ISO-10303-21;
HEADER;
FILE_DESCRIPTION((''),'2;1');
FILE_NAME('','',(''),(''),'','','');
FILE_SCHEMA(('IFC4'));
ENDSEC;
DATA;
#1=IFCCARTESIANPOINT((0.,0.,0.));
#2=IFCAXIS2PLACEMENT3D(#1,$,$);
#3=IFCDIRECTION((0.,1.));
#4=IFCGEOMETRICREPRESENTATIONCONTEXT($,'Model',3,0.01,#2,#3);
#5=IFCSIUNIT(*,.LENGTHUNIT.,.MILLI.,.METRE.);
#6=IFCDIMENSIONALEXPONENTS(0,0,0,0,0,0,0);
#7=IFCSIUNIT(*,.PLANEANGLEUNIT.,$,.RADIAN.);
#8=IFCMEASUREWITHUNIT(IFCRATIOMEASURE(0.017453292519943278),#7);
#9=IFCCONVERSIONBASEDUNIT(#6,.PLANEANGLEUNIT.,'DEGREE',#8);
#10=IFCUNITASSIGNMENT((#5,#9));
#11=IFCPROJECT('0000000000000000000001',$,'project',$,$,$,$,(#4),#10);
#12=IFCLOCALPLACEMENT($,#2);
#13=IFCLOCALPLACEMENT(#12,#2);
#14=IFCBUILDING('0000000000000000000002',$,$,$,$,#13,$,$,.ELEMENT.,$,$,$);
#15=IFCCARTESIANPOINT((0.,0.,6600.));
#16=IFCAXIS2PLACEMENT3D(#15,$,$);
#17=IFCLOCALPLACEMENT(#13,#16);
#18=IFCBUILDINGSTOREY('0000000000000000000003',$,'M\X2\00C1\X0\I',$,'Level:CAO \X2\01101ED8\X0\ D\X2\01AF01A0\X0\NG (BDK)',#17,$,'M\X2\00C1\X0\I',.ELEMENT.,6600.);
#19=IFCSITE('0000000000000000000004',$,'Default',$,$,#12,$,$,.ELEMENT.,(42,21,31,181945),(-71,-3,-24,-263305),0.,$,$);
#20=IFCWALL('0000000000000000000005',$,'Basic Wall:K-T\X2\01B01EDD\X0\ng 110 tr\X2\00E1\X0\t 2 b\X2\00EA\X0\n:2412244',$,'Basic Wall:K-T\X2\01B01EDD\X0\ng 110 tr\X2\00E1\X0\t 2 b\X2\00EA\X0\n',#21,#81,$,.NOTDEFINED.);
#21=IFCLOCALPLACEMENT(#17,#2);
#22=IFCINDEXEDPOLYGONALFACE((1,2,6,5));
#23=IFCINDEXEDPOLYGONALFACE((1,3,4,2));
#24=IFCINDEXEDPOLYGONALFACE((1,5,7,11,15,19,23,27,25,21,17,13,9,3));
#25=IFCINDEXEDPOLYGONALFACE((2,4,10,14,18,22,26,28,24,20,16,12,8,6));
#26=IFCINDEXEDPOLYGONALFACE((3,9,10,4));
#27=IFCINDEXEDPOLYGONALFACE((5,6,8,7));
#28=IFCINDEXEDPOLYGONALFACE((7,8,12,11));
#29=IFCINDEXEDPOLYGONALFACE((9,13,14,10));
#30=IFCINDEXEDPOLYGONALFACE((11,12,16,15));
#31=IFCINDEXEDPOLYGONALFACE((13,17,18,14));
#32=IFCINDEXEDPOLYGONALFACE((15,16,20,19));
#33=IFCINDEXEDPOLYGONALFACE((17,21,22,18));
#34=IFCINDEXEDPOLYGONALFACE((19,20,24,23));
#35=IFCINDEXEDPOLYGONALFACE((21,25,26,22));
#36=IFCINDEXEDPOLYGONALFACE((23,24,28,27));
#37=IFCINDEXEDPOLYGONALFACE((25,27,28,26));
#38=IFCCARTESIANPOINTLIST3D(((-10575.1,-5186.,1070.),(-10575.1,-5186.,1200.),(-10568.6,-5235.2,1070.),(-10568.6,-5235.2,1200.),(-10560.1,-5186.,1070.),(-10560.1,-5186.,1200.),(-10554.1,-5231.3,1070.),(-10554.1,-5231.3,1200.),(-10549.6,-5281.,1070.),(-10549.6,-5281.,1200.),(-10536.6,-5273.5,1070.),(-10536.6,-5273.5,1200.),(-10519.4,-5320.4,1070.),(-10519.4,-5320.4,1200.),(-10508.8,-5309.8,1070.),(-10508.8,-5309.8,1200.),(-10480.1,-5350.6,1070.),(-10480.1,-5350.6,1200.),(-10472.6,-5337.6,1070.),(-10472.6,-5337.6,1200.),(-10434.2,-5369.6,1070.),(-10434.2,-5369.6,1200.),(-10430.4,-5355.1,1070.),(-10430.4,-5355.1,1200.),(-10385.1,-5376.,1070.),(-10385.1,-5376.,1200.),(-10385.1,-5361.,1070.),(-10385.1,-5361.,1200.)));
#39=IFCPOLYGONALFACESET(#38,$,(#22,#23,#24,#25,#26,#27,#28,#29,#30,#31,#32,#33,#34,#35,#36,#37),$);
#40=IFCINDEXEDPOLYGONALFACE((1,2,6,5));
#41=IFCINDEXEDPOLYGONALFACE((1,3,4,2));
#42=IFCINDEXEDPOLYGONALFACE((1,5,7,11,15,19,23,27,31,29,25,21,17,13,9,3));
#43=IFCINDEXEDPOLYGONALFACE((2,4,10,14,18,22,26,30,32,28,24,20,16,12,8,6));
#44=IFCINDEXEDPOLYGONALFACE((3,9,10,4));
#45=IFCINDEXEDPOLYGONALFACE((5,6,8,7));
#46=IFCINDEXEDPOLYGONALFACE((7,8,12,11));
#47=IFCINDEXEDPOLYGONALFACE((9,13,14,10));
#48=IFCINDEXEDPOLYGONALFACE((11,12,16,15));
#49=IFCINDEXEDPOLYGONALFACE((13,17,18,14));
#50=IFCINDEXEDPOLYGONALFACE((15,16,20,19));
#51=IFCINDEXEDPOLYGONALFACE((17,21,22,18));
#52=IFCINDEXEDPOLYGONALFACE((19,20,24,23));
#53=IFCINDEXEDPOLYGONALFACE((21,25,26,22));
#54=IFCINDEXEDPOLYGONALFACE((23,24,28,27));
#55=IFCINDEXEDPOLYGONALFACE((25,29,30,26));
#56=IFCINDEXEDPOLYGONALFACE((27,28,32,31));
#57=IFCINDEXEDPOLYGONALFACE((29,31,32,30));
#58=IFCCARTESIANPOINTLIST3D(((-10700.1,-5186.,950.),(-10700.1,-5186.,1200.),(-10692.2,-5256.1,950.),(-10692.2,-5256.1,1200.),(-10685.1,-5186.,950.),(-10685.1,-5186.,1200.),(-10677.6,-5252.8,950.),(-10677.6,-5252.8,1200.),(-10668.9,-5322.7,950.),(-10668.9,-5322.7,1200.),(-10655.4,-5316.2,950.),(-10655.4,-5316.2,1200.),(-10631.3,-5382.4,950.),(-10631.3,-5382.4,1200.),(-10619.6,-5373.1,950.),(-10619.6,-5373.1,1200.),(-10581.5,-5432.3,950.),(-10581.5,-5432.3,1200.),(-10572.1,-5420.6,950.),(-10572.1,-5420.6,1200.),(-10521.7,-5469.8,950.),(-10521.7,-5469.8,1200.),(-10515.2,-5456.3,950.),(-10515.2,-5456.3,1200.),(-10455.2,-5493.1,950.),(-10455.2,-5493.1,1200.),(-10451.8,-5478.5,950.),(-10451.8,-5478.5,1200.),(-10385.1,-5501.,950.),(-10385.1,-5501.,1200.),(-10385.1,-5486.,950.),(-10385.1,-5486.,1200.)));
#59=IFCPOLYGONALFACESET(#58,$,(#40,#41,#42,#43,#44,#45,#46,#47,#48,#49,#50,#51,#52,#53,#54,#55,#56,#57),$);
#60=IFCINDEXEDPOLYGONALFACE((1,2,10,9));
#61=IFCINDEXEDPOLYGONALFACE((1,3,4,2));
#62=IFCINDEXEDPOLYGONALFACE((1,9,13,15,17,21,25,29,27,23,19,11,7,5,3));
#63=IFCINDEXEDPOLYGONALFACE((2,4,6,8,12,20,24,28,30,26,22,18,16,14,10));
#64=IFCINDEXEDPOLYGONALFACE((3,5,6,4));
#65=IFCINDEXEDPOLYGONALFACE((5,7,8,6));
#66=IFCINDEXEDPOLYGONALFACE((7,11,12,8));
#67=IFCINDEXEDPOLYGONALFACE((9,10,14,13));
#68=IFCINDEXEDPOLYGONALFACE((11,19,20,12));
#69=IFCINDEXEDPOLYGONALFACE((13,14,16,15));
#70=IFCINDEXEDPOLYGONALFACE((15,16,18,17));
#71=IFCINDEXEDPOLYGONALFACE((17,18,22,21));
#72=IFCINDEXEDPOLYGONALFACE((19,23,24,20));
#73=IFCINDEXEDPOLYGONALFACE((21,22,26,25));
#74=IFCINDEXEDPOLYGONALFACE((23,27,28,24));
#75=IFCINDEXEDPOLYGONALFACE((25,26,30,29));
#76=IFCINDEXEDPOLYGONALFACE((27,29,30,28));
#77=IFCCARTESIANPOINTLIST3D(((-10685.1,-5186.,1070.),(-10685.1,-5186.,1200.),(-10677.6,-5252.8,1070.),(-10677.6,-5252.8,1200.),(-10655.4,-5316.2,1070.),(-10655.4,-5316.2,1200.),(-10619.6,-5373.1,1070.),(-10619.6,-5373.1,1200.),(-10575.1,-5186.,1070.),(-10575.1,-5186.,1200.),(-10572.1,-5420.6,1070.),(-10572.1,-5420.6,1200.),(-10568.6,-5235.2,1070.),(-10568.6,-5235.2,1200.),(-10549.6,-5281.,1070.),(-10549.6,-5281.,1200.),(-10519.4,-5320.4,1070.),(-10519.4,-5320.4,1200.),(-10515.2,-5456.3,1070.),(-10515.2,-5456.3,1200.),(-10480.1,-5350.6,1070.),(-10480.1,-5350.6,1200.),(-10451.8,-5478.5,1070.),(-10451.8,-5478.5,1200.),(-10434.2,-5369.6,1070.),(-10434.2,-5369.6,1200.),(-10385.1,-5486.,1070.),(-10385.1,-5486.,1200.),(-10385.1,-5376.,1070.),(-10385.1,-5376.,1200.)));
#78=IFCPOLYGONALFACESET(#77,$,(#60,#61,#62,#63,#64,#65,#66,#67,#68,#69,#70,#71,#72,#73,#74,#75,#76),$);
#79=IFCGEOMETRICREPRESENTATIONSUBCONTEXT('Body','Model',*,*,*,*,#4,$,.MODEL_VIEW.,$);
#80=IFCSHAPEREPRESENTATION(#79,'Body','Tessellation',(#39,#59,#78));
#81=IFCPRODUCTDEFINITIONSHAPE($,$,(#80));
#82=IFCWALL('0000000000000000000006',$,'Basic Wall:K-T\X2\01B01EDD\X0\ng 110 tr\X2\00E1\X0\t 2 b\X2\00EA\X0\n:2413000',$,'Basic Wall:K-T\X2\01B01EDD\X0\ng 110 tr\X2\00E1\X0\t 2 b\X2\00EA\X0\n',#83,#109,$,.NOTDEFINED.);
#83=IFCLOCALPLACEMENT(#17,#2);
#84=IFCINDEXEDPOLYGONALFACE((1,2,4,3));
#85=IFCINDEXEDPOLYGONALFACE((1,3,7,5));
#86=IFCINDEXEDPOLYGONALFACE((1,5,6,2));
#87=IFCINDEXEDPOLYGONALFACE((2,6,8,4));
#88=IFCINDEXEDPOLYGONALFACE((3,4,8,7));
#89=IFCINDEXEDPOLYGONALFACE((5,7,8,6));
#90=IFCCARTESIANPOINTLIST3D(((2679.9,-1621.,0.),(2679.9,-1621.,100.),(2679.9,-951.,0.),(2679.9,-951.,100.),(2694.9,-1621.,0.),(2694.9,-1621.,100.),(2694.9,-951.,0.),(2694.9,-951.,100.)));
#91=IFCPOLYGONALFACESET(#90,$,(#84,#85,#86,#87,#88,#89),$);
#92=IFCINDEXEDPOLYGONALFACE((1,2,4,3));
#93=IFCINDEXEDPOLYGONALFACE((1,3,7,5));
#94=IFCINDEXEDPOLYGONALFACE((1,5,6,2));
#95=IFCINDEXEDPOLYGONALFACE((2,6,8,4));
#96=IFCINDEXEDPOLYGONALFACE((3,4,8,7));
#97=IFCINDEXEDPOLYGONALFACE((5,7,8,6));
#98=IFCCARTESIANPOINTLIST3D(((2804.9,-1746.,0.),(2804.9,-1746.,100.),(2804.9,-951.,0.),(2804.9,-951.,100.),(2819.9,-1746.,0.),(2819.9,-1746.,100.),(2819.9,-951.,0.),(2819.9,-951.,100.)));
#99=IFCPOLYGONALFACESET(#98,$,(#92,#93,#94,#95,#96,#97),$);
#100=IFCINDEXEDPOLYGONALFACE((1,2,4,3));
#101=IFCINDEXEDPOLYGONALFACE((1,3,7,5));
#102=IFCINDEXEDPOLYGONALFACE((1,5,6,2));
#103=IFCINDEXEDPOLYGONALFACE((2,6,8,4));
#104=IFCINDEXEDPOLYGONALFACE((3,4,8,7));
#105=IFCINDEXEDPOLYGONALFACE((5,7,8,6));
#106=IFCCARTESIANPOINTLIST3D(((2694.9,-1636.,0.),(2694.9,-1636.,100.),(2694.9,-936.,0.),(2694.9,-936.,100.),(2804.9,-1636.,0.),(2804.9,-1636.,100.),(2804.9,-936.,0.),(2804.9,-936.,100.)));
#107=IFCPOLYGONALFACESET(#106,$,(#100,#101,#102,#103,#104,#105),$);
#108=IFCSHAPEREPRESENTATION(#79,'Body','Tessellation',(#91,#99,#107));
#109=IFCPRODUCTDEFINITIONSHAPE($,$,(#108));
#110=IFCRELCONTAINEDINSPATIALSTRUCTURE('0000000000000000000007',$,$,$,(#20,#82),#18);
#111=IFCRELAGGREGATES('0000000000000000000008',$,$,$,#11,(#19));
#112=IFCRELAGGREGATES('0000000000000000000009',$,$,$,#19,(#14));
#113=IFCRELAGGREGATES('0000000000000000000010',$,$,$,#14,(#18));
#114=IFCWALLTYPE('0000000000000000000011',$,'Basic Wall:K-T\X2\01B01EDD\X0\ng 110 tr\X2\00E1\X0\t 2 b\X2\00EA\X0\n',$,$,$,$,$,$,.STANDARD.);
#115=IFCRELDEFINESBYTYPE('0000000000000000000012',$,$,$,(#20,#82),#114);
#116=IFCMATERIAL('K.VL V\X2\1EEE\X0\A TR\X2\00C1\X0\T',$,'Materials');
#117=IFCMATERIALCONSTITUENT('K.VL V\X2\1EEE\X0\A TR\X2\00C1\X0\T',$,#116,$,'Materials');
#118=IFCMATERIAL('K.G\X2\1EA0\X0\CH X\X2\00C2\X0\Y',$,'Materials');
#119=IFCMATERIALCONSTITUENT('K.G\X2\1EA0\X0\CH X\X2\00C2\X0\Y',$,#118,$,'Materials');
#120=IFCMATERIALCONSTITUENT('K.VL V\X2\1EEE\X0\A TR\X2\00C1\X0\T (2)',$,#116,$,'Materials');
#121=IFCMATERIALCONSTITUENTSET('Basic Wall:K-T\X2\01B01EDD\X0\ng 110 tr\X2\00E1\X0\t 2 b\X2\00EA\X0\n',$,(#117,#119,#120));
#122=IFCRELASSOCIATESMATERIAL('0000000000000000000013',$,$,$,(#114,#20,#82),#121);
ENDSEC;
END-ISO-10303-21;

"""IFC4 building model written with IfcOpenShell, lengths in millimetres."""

from ifc_helpers import new_model, entity, si_unit, converted_unit, direction, frame, origin, place, context, subcontext, project, spatial, line, arc, indexed_curve, outline, extrude, material, constituent, constituent_set, type_object, element, save


model = new_model("IFC4")

# Units and contexts
model_context = context("Model", 3, precision=0.01, world=origin(), true_north=direction((0.0, 1.0)))
body_context = subcontext(model_context, "Body", "Model", "MODEL_VIEW")
ifc_project = project(units=[si_unit("LENGTHUNIT", "METRE", prefix="MILLI"), converted_unit("PLANEANGLEUNIT", "DEGREE", entity("IfcRatioMeasure", 0.017453292519943278), si_unit("PLANEANGLEUNIT", "RADIAN"), dimensions=[0, 0, 0, 0, 0, 0, 0])], contexts=[model_context])

# Site, building, storey
site_placement = place(None, origin())
site = spatial("IfcSite", under=ifc_project, at=site_placement, Name="Default", CompositionType="ELEMENT", RefLatitude=(42, 21, 31, 181945), RefLongitude=(-71, -3, -24, -263305), RefElevation=0.0)
building_placement = place(site_placement, origin())
building = spatial("IfcBuilding", under=site, at=building_placement, CompositionType="ELEMENT")
storey_placement = place(building_placement, frame((0.0, 0.0, 6600.0)))
storey = spatial("IfcBuildingStorey", under=building, at=storey_placement, Name="MÁI", ObjectType="Level:CAO ĐỘ DƯƠNG (BDK)", LongName="MÁI", CompositionType="ELEMENT", Elevation=6600.0)

# Walls
ifc_material_1 = material(Name="K.VL VỮA TRÁT", Category="Materials")
ifc_material_2 = material(Name="K.GẠCH XÂY", Category="Materials")
ifc_constituent_1 = constituent(ifc_material_1, Name="K.VL VỮA TRÁT", Category="Materials")
ifc_constituent_2 = constituent(ifc_material_2, Name="K.GẠCH XÂY", Category="Materials")
ifc_constituent_3 = constituent(ifc_material_1, Name="K.VL VỮA TRÁT (2)", Category="Materials")
ifc_constituent_set_1 = constituent_set(constituents=[ifc_constituent_1, ifc_constituent_2, ifc_constituent_3], Name="Basic Wall:K-Tường 110 trát 2 bên")
wall_type_1 = type_object("IfcWallType", Name="Basic Wall:K-Tường 110 trát 2 bên", PredefinedType="STANDARD", material=ifc_constituent_set_1)
wall_1_placement = place(storey_placement, frame((-10385.1, -5431.0, 950.0)))
element("IfcWall", 1, at=wall_1_placement, inside=storey, type_object=wall_type_1, material=ifc_constituent_set_1, Name="Basic Wall:K-Tường 110 trát 2 bên:2412244", ObjectType="Basic Wall:K-Tường 110 trát 2 bên", PredefinedType="NOTDEFINED", context=body_context, shape_type="SweptSolid", body=[
    extrude(outline(indexed_curve([(83.7, -91.2), (98.7, -91.2), (43.1, 43.1), (-91.3, 98.8), (-91.3, 83.8), (32.5, 32.5)], segments=[line(1, 2), arc(2, 3, 4), line(4, 5), arc(5, 6, 1)], self_intersect=False)), frame((-91.3, 153.7, 120.0), z_axis=(0.0, 0.0, 1.0), x_axis=(-1.0, 0.0, 0.0)), (0.0, 0.0, 1.0), 130.0),
    extrude(outline(indexed_curve([(-161.3, 153.7), (-69.0, -69.0), (153.7, -161.2), (153.8, -146.2), (-58.4, -58.4), (-146.3, 153.7)], segments=[arc(1, 2, 3), line(3, 4), arc(4, 5, 6), line(6, 1)], self_intersect=False)), frame((-153.8, 91.2, 0.0), z_axis=(0.0, 0.0, -1.0), x_axis=(0.0, 1.0, 0.0)), (0.0, 0.0, -1.0), 250.0),
    extrude(outline(indexed_curve([(68.8, -121.8), (178.8, -120.6), (88.7, 90.6), (-124.3, 176.2), (-123.2, 66.2), (11.7, 12.0)], segments=[line(1, 2), arc(2, 3, 4), line(4, 5), arc(5, 6, 1)], self_intersect=False)), frame((-122.5, 122.5, 120.0), z_axis=(0.0, 0.0, -1.0), x_axis=(0.010416, -0.999946, 0.0)), (0.0, 0.0, -1.0), 130.0),
])
wall_2_placement = place(storey_placement, frame((2749.9, -951.0, 0.0), z_axis=(0.0, 0.0, 1.0), x_axis=(0.0, -1.0, 0.0)))
element("IfcWall", 2, at=wall_2_placement, inside=storey, type_object=wall_type_1, material=ifc_constituent_set_1, Name="Basic Wall:K-Tường 110 trát 2 bên:2413000", ObjectType="Basic Wall:K-Tường 110 trát 2 bên", PredefinedType="NOTDEFINED", context=body_context, shape_type="SweptSolid", body=[
    extrude(outline(indexed_curve([(-7.5, -335.0), (7.5, -335.0), (7.5, 335.0), (-7.5, 335.0), (-7.5, -335.0)], self_intersect=False)), frame((335.0, -62.5, 0.0), z_axis=(0.0, 0.0, 1.0), x_axis=(0.0, 1.0, 0.0)), (0.0, 0.0, 1.0), 100.0),
    extrude(outline(indexed_curve([(-7.5, -397.5), (7.5, -397.5), (7.5, 397.5), (-7.5, 397.5), (-7.5, -397.5)], self_intersect=False)), frame((397.5, 62.5, 0.0), z_axis=(0.0, 0.0, 1.0), x_axis=(0.0, -1.0, 0.0)), (0.0, 0.0, 1.0), 100.0),
    extrude(outline(indexed_curve([(-350.0, -55.0), (350.0, -55.0), (350.0, 55.0), (-350.0, 55.0), (-350.0, -55.0)], self_intersect=False)), frame((335.0, 0.0, 0.0)), (0.0, 0.0, 1.0), 100.0),
])

save(model, "model.ifc")
